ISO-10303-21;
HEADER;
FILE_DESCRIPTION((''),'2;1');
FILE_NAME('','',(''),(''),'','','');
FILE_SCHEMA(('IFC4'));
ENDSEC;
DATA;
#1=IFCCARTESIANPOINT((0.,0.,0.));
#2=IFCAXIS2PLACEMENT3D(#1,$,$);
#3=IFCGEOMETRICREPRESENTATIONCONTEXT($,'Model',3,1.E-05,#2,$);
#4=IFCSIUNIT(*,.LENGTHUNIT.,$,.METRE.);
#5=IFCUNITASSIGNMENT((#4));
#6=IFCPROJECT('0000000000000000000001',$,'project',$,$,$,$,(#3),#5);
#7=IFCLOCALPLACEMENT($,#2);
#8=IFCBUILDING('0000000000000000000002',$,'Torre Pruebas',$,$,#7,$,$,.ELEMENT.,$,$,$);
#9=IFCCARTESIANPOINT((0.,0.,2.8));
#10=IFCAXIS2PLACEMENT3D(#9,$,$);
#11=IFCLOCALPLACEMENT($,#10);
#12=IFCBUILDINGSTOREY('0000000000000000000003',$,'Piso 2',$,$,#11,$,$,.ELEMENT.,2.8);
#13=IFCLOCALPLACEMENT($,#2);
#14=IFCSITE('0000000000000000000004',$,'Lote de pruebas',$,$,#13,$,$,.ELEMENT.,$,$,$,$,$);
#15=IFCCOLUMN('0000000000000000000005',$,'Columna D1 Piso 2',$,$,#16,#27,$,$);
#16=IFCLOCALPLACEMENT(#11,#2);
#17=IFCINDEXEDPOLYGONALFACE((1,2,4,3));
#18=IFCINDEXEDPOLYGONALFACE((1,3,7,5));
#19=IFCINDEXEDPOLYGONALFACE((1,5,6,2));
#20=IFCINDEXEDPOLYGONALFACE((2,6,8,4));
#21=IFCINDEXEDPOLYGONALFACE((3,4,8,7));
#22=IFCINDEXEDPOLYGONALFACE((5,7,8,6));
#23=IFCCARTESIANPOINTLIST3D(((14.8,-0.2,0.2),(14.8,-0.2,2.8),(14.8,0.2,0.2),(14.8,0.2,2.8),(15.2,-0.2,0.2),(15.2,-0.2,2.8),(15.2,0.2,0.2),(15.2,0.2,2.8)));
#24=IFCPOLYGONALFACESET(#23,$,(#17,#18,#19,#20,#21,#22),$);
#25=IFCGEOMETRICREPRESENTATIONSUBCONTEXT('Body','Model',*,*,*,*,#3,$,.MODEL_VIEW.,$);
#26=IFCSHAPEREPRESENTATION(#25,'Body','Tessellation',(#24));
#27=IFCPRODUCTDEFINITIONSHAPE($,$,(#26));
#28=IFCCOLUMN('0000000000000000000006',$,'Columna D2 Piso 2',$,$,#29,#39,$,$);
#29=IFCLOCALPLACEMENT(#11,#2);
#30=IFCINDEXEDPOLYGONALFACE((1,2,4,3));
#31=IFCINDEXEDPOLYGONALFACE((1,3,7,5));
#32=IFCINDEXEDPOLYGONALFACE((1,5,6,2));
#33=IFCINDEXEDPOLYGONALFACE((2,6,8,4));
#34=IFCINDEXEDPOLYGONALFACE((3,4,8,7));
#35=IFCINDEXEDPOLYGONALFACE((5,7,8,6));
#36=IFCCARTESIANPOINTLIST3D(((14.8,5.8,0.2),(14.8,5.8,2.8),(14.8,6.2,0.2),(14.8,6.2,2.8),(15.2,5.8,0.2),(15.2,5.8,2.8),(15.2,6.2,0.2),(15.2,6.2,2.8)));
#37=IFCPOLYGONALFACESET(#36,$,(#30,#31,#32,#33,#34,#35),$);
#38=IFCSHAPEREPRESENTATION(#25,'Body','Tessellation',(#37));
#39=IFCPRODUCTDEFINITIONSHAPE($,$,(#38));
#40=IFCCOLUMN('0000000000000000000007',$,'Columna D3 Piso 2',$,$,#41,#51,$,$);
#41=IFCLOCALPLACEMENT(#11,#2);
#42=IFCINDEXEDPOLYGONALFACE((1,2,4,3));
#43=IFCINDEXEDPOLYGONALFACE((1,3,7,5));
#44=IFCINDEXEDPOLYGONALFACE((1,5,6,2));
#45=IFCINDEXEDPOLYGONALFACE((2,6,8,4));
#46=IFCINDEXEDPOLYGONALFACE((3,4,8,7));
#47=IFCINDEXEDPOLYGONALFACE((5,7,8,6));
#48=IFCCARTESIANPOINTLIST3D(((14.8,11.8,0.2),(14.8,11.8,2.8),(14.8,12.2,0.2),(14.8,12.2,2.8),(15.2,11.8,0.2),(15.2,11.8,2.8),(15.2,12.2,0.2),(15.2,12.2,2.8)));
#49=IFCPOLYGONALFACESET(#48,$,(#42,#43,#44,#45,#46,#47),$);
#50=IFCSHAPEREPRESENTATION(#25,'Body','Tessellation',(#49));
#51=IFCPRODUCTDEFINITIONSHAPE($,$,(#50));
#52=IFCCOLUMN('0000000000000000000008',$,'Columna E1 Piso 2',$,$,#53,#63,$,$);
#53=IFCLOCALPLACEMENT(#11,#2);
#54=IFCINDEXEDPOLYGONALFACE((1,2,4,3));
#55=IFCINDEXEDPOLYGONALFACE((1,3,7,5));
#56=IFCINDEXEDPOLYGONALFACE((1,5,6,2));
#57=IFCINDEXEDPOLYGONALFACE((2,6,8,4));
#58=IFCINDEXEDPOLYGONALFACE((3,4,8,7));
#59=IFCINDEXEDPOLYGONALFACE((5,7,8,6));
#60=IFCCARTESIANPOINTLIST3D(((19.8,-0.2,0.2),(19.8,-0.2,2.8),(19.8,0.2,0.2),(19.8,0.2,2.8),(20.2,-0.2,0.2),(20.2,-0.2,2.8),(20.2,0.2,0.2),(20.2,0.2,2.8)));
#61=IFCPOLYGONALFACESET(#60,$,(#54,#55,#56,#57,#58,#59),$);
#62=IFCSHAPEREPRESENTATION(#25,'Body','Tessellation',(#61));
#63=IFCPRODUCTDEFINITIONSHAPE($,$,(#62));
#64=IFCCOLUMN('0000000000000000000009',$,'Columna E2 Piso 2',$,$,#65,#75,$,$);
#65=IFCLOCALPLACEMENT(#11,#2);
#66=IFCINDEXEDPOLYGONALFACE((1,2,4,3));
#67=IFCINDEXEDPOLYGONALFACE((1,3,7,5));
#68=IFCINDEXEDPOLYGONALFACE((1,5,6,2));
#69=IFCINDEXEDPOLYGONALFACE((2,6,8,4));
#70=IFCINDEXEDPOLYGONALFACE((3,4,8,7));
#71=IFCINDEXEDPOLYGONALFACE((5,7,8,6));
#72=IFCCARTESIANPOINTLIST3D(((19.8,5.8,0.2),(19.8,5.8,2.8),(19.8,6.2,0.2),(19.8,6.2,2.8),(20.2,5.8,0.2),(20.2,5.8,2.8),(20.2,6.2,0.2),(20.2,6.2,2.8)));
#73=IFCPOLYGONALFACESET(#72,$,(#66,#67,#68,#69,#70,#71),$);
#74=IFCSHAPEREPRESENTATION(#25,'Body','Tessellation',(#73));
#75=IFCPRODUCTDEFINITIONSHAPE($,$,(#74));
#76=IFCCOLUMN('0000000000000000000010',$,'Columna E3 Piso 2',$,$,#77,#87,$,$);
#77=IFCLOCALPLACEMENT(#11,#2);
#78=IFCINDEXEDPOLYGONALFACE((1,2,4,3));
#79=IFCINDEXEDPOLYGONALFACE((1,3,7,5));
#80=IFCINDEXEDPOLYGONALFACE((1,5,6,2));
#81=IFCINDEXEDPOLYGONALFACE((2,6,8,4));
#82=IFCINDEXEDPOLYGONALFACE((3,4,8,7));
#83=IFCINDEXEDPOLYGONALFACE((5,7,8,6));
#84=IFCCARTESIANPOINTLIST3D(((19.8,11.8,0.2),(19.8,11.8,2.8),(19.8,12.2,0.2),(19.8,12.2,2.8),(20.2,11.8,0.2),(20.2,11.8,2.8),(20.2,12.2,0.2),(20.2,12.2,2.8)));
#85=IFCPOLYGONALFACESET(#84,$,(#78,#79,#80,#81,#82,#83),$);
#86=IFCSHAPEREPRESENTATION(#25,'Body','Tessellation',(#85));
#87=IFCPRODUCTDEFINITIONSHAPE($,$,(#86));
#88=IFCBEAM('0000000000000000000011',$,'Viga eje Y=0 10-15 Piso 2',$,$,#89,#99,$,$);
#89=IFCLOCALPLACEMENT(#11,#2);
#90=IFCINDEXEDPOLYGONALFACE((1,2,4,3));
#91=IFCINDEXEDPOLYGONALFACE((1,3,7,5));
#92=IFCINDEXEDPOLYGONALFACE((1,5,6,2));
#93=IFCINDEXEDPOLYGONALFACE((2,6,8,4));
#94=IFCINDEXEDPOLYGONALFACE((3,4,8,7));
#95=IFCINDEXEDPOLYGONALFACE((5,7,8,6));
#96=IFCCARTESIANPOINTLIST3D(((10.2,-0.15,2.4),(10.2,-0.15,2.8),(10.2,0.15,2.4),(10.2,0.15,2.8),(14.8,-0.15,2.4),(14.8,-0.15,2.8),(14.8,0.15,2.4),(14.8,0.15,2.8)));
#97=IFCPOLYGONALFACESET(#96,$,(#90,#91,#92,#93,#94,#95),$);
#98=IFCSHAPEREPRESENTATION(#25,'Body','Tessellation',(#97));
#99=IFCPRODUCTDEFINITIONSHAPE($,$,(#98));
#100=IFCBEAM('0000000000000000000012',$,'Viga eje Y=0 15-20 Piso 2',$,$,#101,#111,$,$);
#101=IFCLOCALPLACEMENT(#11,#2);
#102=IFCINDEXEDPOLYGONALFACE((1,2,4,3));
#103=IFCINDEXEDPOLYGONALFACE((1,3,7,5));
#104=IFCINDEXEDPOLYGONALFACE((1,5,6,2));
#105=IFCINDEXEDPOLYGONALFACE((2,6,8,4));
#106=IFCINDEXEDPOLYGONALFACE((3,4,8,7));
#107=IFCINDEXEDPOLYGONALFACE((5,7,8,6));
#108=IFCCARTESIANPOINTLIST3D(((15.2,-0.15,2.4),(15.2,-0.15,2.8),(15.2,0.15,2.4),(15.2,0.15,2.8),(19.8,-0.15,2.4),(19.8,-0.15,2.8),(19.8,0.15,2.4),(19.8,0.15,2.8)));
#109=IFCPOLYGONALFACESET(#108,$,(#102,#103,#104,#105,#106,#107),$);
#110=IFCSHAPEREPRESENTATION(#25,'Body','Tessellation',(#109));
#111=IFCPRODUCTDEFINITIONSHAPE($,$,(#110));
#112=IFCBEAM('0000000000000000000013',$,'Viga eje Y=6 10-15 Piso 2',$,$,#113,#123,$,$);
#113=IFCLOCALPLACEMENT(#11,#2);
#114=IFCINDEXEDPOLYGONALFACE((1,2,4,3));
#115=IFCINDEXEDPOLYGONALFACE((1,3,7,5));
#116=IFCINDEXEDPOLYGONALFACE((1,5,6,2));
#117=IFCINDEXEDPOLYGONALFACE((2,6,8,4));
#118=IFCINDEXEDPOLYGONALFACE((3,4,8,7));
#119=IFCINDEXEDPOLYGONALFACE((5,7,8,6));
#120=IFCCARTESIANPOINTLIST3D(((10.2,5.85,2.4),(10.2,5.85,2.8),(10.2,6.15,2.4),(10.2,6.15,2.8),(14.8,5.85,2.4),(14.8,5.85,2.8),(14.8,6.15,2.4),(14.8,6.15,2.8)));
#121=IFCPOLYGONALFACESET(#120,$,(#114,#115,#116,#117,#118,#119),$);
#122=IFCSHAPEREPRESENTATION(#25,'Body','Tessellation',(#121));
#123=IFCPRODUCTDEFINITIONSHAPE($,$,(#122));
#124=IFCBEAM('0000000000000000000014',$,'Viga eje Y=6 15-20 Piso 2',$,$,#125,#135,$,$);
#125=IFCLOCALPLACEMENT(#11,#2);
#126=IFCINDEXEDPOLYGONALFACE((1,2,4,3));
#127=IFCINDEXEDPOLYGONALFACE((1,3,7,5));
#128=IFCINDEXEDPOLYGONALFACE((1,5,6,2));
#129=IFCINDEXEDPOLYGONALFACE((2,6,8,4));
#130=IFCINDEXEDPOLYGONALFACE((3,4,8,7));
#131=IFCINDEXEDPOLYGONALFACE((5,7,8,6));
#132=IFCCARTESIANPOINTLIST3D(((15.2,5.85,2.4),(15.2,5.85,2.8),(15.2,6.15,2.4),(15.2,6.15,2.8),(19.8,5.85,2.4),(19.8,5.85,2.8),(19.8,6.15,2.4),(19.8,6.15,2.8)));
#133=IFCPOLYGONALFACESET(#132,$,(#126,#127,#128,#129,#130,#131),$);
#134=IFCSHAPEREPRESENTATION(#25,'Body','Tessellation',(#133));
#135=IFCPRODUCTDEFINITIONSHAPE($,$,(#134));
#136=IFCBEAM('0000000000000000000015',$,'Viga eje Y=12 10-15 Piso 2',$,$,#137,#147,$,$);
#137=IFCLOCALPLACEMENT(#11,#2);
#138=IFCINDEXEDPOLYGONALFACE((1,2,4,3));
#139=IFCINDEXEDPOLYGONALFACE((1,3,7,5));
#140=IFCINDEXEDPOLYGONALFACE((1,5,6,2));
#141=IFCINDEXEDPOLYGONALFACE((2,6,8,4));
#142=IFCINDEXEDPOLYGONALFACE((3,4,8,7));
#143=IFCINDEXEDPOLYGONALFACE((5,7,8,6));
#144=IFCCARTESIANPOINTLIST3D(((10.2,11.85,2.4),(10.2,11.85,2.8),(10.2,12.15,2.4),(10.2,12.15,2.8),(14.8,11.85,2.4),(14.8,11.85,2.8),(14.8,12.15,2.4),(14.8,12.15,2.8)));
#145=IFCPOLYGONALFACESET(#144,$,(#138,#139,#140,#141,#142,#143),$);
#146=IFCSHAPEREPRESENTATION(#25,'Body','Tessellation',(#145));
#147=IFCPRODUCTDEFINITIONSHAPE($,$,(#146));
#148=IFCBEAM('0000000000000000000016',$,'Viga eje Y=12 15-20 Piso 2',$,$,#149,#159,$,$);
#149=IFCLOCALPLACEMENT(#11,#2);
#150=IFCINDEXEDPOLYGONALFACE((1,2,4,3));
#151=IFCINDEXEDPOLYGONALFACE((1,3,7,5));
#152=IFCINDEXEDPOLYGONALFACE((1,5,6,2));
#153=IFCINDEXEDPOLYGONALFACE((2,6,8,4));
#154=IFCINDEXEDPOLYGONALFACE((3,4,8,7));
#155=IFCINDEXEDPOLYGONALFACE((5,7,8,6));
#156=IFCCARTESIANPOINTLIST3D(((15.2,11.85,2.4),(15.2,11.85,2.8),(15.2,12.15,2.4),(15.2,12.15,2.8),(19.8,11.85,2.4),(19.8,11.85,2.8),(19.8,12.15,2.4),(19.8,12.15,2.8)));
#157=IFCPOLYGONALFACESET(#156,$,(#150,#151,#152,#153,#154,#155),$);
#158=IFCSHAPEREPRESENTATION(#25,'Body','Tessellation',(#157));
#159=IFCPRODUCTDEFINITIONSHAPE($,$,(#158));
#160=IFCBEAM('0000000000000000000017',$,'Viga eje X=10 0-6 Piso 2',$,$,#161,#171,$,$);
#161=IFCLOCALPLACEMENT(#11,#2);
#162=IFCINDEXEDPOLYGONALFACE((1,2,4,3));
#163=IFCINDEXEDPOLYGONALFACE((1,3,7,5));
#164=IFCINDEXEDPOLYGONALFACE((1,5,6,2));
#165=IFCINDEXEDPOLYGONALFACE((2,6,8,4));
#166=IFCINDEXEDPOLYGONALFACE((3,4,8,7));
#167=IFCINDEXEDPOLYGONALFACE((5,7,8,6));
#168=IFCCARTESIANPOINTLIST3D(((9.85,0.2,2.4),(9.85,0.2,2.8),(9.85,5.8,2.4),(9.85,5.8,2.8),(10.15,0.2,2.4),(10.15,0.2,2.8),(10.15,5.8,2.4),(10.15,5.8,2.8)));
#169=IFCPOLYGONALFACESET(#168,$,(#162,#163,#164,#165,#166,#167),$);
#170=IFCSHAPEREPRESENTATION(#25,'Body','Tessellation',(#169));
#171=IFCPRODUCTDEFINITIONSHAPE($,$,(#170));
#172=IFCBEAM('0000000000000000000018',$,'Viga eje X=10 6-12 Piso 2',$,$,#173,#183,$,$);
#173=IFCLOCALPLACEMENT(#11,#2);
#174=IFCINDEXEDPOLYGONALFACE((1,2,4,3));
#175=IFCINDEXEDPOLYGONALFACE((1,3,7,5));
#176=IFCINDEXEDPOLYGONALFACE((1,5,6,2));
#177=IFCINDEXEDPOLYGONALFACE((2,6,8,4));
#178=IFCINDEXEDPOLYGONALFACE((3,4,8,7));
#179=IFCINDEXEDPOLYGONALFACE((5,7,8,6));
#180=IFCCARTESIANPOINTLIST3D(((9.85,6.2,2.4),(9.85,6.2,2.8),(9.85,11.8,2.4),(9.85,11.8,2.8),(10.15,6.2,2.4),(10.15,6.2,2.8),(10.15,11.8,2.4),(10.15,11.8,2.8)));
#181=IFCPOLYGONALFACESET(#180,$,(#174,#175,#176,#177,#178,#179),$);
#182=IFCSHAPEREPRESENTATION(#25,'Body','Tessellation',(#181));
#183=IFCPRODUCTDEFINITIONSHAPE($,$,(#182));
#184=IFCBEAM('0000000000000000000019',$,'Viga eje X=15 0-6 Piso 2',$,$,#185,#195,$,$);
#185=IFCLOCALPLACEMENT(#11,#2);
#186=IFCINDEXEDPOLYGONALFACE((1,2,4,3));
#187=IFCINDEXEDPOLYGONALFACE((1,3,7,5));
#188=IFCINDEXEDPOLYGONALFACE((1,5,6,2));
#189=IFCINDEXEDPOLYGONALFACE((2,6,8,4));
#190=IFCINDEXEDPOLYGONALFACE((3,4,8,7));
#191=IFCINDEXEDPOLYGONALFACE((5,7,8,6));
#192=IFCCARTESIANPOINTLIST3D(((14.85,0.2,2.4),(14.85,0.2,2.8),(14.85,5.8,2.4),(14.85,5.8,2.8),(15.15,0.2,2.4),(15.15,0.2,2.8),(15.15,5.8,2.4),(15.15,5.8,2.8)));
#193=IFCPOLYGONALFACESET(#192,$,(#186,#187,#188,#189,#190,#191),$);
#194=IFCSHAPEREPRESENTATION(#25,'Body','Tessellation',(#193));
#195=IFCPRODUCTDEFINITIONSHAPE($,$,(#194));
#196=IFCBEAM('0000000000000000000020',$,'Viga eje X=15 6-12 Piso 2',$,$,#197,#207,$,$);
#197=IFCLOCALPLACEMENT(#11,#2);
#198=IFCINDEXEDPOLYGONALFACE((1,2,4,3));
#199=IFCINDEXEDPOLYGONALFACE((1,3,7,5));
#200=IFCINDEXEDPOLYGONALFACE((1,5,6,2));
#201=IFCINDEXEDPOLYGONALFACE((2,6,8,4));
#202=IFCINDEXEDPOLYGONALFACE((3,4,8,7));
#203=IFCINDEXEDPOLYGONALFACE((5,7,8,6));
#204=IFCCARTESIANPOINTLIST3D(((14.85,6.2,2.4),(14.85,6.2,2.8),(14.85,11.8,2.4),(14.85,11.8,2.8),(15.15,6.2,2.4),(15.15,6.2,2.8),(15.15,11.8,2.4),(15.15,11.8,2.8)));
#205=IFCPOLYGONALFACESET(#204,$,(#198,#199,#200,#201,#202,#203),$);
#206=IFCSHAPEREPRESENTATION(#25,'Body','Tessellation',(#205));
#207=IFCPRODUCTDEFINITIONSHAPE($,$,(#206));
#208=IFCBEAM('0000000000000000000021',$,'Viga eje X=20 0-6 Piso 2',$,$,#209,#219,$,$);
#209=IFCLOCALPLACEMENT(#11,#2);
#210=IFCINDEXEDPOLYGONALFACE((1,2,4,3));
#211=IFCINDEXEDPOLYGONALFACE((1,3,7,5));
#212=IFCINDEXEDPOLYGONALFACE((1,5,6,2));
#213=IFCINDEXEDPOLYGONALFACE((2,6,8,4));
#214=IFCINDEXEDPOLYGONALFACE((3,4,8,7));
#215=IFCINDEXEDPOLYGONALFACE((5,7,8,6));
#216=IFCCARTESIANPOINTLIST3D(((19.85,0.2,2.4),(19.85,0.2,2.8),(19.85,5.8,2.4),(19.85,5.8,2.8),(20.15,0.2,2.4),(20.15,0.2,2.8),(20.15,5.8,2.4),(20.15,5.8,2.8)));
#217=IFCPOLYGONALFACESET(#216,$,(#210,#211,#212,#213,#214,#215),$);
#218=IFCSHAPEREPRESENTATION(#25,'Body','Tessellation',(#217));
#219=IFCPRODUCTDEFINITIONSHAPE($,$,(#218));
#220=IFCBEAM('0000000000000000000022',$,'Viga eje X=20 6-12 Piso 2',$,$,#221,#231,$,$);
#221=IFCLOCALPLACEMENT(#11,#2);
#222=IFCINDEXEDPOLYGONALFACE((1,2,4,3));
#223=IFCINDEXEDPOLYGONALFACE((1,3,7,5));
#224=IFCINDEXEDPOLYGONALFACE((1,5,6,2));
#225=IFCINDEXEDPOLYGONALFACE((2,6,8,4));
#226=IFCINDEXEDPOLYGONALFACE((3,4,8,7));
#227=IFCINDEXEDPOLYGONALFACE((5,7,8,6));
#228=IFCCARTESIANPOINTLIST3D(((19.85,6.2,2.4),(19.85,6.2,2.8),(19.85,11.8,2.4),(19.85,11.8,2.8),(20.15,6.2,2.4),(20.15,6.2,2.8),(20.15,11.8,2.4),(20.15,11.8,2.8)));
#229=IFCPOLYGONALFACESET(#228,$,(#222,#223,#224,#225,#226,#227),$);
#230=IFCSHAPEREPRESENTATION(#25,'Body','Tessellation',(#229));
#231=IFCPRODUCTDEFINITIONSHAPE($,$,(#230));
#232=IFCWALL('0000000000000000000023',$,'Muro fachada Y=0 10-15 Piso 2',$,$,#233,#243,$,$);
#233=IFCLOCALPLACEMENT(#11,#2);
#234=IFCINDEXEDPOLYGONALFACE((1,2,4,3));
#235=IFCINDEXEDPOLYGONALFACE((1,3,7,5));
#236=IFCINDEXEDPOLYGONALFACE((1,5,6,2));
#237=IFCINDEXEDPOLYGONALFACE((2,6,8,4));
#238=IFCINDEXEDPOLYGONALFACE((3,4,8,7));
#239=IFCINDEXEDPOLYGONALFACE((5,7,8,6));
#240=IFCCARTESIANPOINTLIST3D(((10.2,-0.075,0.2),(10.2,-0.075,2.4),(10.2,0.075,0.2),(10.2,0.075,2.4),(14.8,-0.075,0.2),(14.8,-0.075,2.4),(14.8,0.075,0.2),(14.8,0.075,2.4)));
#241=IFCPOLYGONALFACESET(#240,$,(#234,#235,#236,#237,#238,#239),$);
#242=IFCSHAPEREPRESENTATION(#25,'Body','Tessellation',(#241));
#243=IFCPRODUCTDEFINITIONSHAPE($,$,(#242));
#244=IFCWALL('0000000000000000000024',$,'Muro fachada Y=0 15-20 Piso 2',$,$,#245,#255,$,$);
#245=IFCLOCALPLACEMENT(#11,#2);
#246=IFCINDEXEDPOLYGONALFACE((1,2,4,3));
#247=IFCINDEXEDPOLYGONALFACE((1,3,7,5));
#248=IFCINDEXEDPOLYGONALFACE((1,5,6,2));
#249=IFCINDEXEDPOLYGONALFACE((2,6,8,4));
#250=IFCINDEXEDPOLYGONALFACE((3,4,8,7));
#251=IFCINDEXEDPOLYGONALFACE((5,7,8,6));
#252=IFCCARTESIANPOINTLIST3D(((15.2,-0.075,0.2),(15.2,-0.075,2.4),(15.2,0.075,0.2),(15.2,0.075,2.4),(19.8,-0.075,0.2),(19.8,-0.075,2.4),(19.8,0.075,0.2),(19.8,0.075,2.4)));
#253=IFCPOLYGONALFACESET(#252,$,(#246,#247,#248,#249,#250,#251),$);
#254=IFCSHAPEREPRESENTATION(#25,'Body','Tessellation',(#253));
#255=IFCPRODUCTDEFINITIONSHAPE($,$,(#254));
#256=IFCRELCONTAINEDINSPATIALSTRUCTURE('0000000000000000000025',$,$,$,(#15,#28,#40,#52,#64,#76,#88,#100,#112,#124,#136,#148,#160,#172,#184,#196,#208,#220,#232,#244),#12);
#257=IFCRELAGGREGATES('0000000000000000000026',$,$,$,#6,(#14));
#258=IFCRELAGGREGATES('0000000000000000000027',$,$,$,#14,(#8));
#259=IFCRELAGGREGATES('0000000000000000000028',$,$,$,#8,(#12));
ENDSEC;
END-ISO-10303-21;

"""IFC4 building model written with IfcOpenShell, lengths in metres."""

from ifc_helpers import new_model, si_unit, frame, origin, origin_2d, place, context, subcontext, project, spatial, rectangle, extrude, element, save


model = new_model("IFC4")

# Units and contexts
model_context = context("Model", 3, precision=1e-05, world=origin())
body_context = subcontext(model_context, "Body", "Model", "MODEL_VIEW")
ifc_project = project(units=[si_unit("LENGTHUNIT", "METRE")], contexts=[model_context])

# Site, building, storey
site_placement = place(None, origin())
site = spatial("IfcSite", under=ifc_project, at=site_placement, Name="Lote de pruebas", CompositionType="ELEMENT")
building_placement = place(None, origin())
building = spatial("IfcBuilding", under=site, at=building_placement, Name="Torre Pruebas", CompositionType="ELEMENT")
storey_placement = place(None, frame((0.0, 0.0, 2.8)))
storey = spatial("IfcBuildingStorey", under=building, at=storey_placement, Name="Piso 2", CompositionType="ELEMENT", Elevation=2.8)

# Columns
for number, where, name in (
    (1, (15.0, 0.0, 3.0), "Columna D1 Piso 2"),
    (2, (15.0, 6.0, 3.0), "Columna D2 Piso 2"),
    (3, (15.0, 12.0, 3.0), "Columna D3 Piso 2"),
    (4, (20.0, 0.0, 3.0), "Columna E1 Piso 2"),
    (5, (20.0, 6.0, 3.0), "Columna E2 Piso 2"),
    (6, (20.0, 12.0, 3.0), "Columna E3 Piso 2"),
):
    element("IfcColumn", number, at=place(None, frame(where)), inside=storey, Name=name, context=body_context, shape_type="SweptSolid", body=[
        extrude(rectangle(XDim=0.4, YDim=0.4, at=origin_2d()), origin(), (0.0, 0.0, 1.0), 2.6),
    ])

# Beams
for number, where, name in (
    (7, (12.5, 0.0, 5.2), "Viga eje Y=0 10-15 Piso 2"),
    (8, (17.5, 0.0, 5.2), "Viga eje Y=0 15-20 Piso 2"),
    (9, (12.5, 6.0, 5.2), "Viga eje Y=6 10-15 Piso 2"),
    (10, (17.5, 6.0, 5.2), "Viga eje Y=6 15-20 Piso 2"),
    (11, (12.5, 12.0, 5.2), "Viga eje Y=12 10-15 Piso 2"),
    (12, (17.5, 12.0, 5.2), "Viga eje Y=12 15-20 Piso 2"),
):
    element("IfcBeam", number, at=place(None, frame(where)), inside=storey, Name=name, context=body_context, shape_type="SweptSolid", body=[
        extrude(rectangle(XDim=4.6, YDim=0.3, at=origin_2d()), origin(), (0.0, 0.0, 1.0), 0.4),
    ])
for number, where, name in (
    (13, (10.0, 3.0, 5.2), "Viga eje X=10 0-6 Piso 2"),
    (14, (10.0, 9.0, 5.2), "Viga eje X=10 6-12 Piso 2"),
    (15, (15.0, 3.0, 5.2), "Viga eje X=15 0-6 Piso 2"),
    (16, (15.0, 9.0, 5.2), "Viga eje X=15 6-12 Piso 2"),
    (17, (20.0, 3.0, 5.2), "Viga eje X=20 0-6 Piso 2"),
    (18, (20.0, 9.0, 5.2), "Viga eje X=20 6-12 Piso 2"),
):
    element("IfcBeam", number, at=place(None, frame(where)), inside=storey, Name=name, context=body_context, shape_type="SweptSolid", body=[
        extrude(rectangle(XDim=0.3, YDim=5.6, at=origin_2d()), origin(), (0.0, 0.0, 1.0), 0.4),
    ])

# Walls
for number, where, name in (
    (19, (12.5, 0.0, 3.0), "Muro fachada Y=0 10-15 Piso 2"),
    (20, (17.5, 0.0, 3.0), "Muro fachada Y=0 15-20 Piso 2"),
):
    element("IfcWall", number, at=place(None, frame(where)), inside=storey, Name=name, context=body_context, shape_type="SweptSolid", body=[
        extrude(rectangle(XDim=4.6, YDim=0.15, at=origin_2d()), origin(), (0.0, 0.0, 1.0), 2.2),
    ])

save(model, "model.ifc")
